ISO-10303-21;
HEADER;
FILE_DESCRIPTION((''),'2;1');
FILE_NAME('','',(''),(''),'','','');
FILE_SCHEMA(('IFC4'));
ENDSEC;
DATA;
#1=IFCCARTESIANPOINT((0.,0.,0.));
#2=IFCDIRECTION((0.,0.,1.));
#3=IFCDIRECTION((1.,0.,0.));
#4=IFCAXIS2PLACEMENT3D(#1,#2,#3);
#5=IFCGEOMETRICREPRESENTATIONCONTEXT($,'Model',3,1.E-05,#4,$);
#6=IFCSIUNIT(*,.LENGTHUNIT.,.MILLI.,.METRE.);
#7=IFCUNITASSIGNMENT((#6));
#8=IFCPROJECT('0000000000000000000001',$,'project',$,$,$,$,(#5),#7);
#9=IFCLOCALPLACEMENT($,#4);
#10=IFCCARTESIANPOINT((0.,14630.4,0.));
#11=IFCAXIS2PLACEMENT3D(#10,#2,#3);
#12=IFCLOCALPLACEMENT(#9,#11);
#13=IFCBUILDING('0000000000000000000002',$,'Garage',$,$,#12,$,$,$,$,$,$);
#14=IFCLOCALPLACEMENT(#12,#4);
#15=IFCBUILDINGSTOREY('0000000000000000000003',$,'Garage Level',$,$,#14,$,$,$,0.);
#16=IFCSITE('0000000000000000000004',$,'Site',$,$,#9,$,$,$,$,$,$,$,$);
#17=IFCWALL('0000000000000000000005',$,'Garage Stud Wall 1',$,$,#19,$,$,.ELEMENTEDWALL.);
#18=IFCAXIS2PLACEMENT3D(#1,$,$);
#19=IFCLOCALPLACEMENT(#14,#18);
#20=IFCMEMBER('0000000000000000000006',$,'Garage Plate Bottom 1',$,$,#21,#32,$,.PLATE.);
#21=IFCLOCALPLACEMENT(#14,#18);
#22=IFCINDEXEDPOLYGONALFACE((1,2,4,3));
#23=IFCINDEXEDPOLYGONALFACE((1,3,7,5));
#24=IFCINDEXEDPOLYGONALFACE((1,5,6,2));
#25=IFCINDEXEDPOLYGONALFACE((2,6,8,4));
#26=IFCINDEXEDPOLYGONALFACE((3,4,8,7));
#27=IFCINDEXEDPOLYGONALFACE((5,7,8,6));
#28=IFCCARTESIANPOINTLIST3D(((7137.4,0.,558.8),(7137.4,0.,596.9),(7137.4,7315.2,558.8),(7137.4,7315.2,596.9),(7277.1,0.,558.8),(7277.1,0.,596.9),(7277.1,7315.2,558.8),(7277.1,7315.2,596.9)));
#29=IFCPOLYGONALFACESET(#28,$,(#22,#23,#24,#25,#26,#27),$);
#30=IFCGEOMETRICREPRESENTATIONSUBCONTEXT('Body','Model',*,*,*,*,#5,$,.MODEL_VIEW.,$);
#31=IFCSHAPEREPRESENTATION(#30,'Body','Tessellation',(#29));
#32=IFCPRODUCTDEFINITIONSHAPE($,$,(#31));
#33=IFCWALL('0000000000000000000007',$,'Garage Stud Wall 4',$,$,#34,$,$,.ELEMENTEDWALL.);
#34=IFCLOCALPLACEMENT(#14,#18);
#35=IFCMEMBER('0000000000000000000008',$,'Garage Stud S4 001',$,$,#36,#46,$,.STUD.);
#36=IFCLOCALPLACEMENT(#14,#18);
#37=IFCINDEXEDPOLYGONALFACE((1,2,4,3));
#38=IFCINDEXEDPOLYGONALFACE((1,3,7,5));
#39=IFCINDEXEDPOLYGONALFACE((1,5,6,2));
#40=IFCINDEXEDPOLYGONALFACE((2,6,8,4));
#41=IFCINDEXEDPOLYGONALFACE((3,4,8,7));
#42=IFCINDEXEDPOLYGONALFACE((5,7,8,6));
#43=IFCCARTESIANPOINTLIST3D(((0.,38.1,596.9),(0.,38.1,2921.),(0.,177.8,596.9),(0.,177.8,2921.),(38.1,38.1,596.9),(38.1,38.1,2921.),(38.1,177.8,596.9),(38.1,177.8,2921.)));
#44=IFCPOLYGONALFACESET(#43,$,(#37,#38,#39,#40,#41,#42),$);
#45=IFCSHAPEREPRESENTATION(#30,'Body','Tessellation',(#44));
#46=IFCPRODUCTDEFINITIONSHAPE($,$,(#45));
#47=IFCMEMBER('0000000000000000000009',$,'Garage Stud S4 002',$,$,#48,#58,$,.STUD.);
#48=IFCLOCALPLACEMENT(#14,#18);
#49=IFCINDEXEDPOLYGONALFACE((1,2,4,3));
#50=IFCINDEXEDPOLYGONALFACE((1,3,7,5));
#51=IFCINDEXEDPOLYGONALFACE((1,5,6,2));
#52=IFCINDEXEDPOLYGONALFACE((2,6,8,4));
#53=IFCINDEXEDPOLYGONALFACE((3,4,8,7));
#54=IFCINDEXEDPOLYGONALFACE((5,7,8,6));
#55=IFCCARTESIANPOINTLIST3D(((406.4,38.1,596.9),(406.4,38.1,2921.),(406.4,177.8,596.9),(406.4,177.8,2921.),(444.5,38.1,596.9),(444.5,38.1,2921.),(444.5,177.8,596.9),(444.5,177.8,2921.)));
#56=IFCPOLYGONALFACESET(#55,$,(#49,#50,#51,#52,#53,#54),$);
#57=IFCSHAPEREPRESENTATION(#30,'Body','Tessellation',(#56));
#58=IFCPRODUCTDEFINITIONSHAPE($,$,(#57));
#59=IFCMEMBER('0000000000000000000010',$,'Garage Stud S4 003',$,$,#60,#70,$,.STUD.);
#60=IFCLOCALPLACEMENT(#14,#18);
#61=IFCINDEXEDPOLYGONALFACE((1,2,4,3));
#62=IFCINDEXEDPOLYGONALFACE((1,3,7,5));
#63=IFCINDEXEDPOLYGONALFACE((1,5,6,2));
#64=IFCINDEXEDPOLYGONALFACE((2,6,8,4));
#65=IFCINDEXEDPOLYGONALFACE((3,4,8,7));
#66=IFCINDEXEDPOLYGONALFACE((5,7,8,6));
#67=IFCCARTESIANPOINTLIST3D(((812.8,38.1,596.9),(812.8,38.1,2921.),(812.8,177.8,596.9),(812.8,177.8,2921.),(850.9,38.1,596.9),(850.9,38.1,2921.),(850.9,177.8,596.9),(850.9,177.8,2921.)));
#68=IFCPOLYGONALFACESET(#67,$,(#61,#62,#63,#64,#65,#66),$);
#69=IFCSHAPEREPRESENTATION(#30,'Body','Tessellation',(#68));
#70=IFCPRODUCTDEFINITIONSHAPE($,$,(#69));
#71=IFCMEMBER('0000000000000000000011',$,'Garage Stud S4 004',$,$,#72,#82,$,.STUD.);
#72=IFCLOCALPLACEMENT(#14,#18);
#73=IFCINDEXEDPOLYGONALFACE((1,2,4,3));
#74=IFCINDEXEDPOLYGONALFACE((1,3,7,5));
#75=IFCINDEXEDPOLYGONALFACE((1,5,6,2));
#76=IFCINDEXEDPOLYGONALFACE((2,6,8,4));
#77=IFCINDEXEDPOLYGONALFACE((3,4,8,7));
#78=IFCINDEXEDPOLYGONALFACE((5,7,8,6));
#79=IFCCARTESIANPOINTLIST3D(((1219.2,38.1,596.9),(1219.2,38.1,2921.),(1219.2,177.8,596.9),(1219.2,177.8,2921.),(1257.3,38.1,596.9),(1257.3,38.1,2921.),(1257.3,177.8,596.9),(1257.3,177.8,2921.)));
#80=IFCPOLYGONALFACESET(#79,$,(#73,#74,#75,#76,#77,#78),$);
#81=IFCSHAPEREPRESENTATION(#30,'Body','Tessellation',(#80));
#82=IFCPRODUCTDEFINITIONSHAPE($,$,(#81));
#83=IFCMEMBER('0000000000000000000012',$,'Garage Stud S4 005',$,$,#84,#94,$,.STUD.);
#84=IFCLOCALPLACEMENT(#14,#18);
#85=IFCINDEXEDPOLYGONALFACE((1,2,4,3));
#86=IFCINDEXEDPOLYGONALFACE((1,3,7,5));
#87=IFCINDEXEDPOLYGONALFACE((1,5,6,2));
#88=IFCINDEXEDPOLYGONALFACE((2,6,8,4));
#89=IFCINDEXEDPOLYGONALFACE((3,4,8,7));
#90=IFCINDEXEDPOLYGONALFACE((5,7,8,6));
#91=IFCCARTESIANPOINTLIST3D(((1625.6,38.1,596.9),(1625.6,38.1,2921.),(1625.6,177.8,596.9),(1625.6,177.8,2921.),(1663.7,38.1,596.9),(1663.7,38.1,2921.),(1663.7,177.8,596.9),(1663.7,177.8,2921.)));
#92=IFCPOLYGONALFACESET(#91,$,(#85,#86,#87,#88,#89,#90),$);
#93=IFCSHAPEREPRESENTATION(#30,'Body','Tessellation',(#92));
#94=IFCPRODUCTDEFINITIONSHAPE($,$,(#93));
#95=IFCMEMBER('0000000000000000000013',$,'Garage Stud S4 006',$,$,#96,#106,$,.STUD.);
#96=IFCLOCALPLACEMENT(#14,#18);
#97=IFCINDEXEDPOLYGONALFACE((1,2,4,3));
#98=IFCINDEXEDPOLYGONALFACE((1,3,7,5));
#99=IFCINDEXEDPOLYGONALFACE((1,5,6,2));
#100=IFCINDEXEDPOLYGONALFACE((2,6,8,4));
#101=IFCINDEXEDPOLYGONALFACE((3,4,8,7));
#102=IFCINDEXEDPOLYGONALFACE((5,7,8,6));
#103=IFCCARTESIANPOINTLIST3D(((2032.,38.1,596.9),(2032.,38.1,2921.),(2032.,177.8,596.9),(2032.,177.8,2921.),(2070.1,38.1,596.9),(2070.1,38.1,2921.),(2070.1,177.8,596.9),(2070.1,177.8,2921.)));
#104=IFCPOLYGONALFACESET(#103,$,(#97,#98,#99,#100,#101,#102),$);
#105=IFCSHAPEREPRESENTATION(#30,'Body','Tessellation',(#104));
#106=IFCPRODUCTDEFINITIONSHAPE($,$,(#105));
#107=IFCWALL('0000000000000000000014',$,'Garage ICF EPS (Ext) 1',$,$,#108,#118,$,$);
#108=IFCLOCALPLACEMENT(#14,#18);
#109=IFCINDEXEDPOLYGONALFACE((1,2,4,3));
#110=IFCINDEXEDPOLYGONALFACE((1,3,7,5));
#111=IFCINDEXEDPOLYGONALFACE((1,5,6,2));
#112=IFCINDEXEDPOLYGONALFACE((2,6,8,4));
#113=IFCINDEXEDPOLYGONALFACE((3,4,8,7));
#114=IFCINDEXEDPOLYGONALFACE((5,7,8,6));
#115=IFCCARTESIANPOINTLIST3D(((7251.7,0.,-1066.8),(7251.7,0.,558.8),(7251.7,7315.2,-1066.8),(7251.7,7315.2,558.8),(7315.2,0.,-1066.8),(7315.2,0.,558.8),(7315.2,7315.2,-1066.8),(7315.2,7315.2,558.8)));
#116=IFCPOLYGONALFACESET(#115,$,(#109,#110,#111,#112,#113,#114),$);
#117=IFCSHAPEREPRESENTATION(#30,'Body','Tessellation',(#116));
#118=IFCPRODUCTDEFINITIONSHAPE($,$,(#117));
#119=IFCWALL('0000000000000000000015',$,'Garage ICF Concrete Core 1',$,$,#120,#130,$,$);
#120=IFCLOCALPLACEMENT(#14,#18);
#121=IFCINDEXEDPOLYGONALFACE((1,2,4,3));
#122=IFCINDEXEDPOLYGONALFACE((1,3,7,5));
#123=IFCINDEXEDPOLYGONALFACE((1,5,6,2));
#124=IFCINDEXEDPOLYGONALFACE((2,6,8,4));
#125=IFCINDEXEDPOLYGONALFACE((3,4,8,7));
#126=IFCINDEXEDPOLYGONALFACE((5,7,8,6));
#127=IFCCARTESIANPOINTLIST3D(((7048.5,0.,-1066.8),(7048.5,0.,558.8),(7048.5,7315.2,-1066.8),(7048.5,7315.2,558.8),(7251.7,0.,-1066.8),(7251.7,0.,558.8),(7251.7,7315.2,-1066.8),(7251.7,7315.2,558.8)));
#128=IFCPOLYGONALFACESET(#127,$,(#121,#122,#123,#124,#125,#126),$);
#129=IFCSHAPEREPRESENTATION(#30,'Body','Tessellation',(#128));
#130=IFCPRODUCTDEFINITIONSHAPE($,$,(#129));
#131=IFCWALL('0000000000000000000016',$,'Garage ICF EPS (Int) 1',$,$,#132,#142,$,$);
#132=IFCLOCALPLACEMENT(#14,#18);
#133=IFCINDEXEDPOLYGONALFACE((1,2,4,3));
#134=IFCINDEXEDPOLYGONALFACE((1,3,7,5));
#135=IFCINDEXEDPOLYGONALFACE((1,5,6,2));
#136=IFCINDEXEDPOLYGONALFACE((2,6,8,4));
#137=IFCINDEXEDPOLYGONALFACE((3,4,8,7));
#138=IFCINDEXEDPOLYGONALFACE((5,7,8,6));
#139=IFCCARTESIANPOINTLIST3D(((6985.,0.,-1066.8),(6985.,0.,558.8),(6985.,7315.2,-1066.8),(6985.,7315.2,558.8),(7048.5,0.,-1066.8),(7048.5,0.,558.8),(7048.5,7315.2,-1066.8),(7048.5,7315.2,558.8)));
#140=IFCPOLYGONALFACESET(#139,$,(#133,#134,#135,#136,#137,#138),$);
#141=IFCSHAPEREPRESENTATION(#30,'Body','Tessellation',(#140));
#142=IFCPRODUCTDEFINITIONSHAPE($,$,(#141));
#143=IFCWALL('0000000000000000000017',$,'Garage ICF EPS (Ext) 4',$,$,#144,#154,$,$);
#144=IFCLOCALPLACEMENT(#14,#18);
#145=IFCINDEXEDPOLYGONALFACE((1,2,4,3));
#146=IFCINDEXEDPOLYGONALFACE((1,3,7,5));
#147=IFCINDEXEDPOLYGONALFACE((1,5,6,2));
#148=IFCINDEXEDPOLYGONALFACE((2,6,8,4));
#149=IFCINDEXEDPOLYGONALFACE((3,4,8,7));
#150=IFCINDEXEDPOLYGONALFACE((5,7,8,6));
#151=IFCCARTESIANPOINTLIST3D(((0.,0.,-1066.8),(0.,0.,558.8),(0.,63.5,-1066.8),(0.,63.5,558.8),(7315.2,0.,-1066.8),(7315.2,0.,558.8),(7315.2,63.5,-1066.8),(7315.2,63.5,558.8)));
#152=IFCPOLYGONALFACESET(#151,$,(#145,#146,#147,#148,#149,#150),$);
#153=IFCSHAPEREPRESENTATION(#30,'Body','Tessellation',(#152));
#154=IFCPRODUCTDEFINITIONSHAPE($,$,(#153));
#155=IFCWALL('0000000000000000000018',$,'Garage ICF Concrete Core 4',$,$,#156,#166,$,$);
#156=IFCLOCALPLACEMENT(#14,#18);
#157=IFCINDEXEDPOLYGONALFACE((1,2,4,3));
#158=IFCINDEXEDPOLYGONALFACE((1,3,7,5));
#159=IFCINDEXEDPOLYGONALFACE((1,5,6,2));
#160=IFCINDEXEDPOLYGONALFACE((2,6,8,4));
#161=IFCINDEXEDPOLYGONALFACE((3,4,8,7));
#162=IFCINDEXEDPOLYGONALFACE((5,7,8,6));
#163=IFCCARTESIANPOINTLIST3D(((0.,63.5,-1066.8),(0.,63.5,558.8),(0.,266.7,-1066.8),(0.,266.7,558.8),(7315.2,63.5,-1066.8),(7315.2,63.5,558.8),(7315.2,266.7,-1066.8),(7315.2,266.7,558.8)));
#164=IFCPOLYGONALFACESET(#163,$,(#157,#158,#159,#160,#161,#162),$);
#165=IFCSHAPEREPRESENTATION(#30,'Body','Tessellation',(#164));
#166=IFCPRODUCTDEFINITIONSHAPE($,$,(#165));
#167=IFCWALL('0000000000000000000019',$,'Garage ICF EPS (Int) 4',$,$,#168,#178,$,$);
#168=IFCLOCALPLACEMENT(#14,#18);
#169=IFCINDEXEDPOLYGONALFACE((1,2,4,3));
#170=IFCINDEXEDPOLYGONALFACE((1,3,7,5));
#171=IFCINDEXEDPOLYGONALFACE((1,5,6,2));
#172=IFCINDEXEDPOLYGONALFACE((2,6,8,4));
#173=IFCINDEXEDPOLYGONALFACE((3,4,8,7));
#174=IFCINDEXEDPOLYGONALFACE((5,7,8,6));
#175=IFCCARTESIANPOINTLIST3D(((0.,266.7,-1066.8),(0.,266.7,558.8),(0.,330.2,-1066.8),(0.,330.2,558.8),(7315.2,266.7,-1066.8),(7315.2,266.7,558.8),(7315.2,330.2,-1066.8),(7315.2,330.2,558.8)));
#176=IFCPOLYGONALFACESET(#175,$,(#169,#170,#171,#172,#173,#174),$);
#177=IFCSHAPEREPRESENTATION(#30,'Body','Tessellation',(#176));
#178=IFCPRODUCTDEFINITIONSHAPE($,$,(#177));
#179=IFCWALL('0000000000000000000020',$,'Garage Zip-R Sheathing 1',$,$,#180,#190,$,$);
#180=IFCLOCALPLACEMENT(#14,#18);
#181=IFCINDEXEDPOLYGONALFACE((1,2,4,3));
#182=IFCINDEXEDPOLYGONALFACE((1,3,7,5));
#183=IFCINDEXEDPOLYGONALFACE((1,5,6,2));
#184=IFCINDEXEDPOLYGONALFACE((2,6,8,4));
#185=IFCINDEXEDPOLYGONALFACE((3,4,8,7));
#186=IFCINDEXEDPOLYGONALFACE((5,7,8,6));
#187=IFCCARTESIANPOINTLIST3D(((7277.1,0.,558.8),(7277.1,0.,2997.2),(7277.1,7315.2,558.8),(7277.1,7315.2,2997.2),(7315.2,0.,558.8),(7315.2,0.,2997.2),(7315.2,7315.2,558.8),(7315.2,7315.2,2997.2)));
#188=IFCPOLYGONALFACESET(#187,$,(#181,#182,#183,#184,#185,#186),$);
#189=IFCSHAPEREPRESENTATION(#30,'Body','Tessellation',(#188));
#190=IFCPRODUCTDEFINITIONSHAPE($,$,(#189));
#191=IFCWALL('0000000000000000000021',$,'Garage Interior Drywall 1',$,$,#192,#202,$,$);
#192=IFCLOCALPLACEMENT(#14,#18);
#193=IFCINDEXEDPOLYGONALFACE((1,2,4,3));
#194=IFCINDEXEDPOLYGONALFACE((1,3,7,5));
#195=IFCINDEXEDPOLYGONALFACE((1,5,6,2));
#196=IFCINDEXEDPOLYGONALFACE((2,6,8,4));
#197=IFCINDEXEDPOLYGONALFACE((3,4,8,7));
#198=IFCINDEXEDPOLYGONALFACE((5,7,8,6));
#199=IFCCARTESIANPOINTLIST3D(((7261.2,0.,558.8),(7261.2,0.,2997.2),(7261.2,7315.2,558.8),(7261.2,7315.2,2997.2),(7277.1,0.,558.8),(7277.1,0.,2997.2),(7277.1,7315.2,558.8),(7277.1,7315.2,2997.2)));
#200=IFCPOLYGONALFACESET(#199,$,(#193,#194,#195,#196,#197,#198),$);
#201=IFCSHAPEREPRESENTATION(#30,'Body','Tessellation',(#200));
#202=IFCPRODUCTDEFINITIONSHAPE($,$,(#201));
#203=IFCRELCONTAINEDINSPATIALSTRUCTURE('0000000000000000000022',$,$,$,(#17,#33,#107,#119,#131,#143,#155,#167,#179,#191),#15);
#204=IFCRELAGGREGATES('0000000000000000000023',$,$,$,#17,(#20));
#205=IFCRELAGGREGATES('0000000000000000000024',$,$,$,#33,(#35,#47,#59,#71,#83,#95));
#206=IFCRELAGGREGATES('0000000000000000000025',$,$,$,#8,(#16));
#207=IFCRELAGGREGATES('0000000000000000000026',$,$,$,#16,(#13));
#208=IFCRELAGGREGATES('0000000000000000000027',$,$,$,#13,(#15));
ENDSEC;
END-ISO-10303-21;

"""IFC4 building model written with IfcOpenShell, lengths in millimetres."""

from ifc_helpers import new_model, si_unit, frame, origin_with_axes, origin_2d, place, context, subcontext, project, spatial, indexed_curve, rectangle, outline, extrude, element, aggregate, save


model = new_model("IFC4")

# Units and contexts
model_context = context("Model", 3, precision=1e-05, world=origin_with_axes())
body_context = subcontext(model_context, "Body", "Model", "MODEL_VIEW")
ifc_project = project(units=[si_unit("LENGTHUNIT", "METRE", prefix="MILLI")], contexts=[model_context])

# Site, building, storey
site_placement = place(None, origin_with_axes())
site = spatial("IfcSite", under=ifc_project, at=site_placement, Name="Site")
building_placement = place(site_placement, frame((0.0, 14630.4, 0.0), z_axis=(0.0, 0.0, 1.0), x_axis=(1.0, 0.0, 0.0)))
building = spatial("IfcBuilding", under=site, at=building_placement, Name="Garage")
storey_placement = place(building_placement, origin_with_axes())
storey = spatial("IfcBuildingStorey", under=building, at=storey_placement, Name="Garage Level", Elevation=0.0)

# Wall, member
wall_1_placement = place(storey_placement, frame((7315.2, 0.0, 558.8), z_axis=(0.0, 0.0, 1.0), x_axis=(0.0, 1.0, 0.0)))
wall_1 = element("IfcWall", 1, at=wall_1_placement, inside=storey, Name="Garage Stud Wall 1", PredefinedType="ELEMENTEDWALL")
member_1_placement = place(wall_1_placement, frame((0.0, 108.0, 19.1), z_axis=(1.0, 0.0, 0.0), x_axis=(0.0, 0.0, 1.0)))
member_1 = element("IfcMember", 2, at=member_1_placement, Name="Garage Plate Bottom 1", PredefinedType="PLATE", context=body_context, shape_type="SweptSolid", body=[
    extrude(rectangle(XDim=38.1, YDim=139.7, at=origin_2d()), origin_with_axes(), (0.0, 0.0, 1.0), 7315.2),
])
aggregate(wall_1, [member_1])

# Wall, members
wall_2_placement = place(storey_placement, frame((0.0, 0.0, 558.8), z_axis=(0.0, 0.0, 1.0), x_axis=(1.0, 0.0, 0.0)))
wall_2 = element("IfcWall", 3, at=wall_2_placement, inside=storey, Name="Garage Stud Wall 4", PredefinedType="ELEMENTEDWALL")
member_2_placement = place(wall_2_placement, frame((19.1, 108.0, 38.1), z_axis=(0.0, 0.0, 1.0), x_axis=(1.0, 0.0, 0.0)))
member_2 = element("IfcMember", 4, at=member_2_placement, Name="Garage Stud S4 001", PredefinedType="STUD", context=body_context, shape_type="SweptSolid", body=[
    extrude(rectangle(XDim=38.1, YDim=139.7, at=origin_2d()), origin_with_axes(), (0.0, 0.0, 1.0), 2324.1),
])
member_3_placement = place(wall_2_placement, frame((425.4, 108.0, 38.1), z_axis=(0.0, 0.0, 1.0), x_axis=(1.0, 0.0, 0.0)))
member_3 = element("IfcMember", 5, at=member_3_placement, Name="Garage Stud S4 002", PredefinedType="STUD", context=body_context, shape_type="SweptSolid", body=[
    extrude(rectangle(XDim=38.1, YDim=139.7, at=origin_2d()), origin_with_axes(), (0.0, 0.0, 1.0), 2324.1),
])
member_4_placement = place(wall_2_placement, frame((831.9, 108.0, 38.1), z_axis=(0.0, 0.0, 1.0), x_axis=(1.0, 0.0, 0.0)))
member_4 = element("IfcMember", 6, at=member_4_placement, Name="Garage Stud S4 003", PredefinedType="STUD", context=body_context, shape_type="SweptSolid", body=[
    extrude(rectangle(XDim=38.1, YDim=139.7, at=origin_2d()), origin_with_axes(), (0.0, 0.0, 1.0), 2324.1),
])
member_5_placement = place(wall_2_placement, frame((1238.2, 108.0, 38.1), z_axis=(0.0, 0.0, 1.0), x_axis=(1.0, 0.0, 0.0)))
member_5 = element("IfcMember", 7, at=member_5_placement, Name="Garage Stud S4 004", PredefinedType="STUD", context=body_context, shape_type="SweptSolid", body=[
    extrude(rectangle(XDim=38.1, YDim=139.7, at=origin_2d()), origin_with_axes(), (0.0, 0.0, 1.0), 2324.1),
])
member_6_placement = place(wall_2_placement, frame((1644.7, 108.0, 38.1), z_axis=(0.0, 0.0, 1.0), x_axis=(1.0, 0.0, 0.0)))
member_6 = element("IfcMember", 8, at=member_6_placement, Name="Garage Stud S4 005", PredefinedType="STUD", context=body_context, shape_type="SweptSolid", body=[
    extrude(rectangle(XDim=38.1, YDim=139.7, at=origin_2d()), origin_with_axes(), (0.0, 0.0, 1.0), 2324.1),
])
member_7_placement = place(wall_2_placement, frame((2051.1, 108.0, 38.1), z_axis=(0.0, 0.0, 1.0), x_axis=(1.0, 0.0, 0.0)))
member_7 = element("IfcMember", 9, at=member_7_placement, Name="Garage Stud S4 006", PredefinedType="STUD", context=body_context, shape_type="SweptSolid", body=[
    extrude(rectangle(XDim=38.1, YDim=139.7, at=origin_2d()), origin_with_axes(), (0.0, 0.0, 1.0), 2324.1),
])
aggregate(wall_2, [member_2, member_3, member_4, member_5, member_6, member_7])

# Walls
wall_3_placement = place(storey_placement, frame((7315.2, 0.0, -1066.8), z_axis=(0.0, 0.0, 1.0), x_axis=(0.0, 1.0, 0.0)))
element("IfcWall", 10, at=wall_3_placement, inside=storey, Name="Garage ICF EPS (Ext) 1", context=body_context, shape_type="SweptSolid", body=[
    extrude(outline(indexed_curve([(0.0, 0.0), (0.0, 63.5), (7315.2, 63.5), (7315.2, 0.0), (0.0, 0.0)], self_intersect=False)), origin_with_axes(), (0.0, 0.0, 1.0), 1625.6),
])
wall_4_placement = place(storey_placement, frame((7315.2, 0.0, -1066.8), z_axis=(0.0, 0.0, 1.0), x_axis=(0.0, 1.0, 0.0)))
element("IfcWall", 11, at=wall_4_placement, inside=storey, Name="Garage ICF Concrete Core 1", context=body_context, shape_type="SweptSolid", body=[
    extrude(outline(indexed_curve([(0.0, 0.0), (0.0, 203.2), (7315.2, 203.2), (7315.2, 0.0), (0.0, 0.0)], self_intersect=False)), frame((0.0, 63.5, 0.0), z_axis=(0.0, 0.0, 1.0), x_axis=(1.0, 0.0, 0.0)), (0.0, 0.0, 1.0), 1625.6),
])
wall_5_placement = place(storey_placement, frame((7315.2, 0.0, -1066.8), z_axis=(0.0, 0.0, 1.0), x_axis=(0.0, 1.0, 0.0)))
element("IfcWall", 12, at=wall_5_placement, inside=storey, Name="Garage ICF EPS (Int) 1", context=body_context, shape_type="SweptSolid", body=[
    extrude(outline(indexed_curve([(0.0, 0.0), (0.0, 63.5), (7315.2, 63.5), (7315.2, 0.0), (0.0, 0.0)], self_intersect=False)), frame((0.0, 266.7, 0.0), z_axis=(0.0, 0.0, 1.0), x_axis=(1.0, 0.0, 0.0)), (0.0, 0.0, 1.0), 1625.6),
])
wall_6_placement = place(storey_placement, frame((0.0, 0.0, -1066.8), z_axis=(0.0, 0.0, 1.0), x_axis=(1.0, 0.0, 0.0)))
element("IfcWall", 13, at=wall_6_placement, inside=storey, Name="Garage ICF EPS (Ext) 4", context=body_context, shape_type="SweptSolid", body=[
    extrude(outline(indexed_curve([(0.0, 0.0), (0.0, 63.5), (7315.2, 63.5), (7315.2, 0.0), (0.0, 0.0)], self_intersect=False)), origin_with_axes(), (0.0, 0.0, 1.0), 1625.6),
])
wall_7_placement = place(storey_placement, frame((0.0, 0.0, -1066.8), z_axis=(0.0, 0.0, 1.0), x_axis=(1.0, 0.0, 0.0)))
element("IfcWall", 14, at=wall_7_placement, inside=storey, Name="Garage ICF Concrete Core 4", context=body_context, shape_type="SweptSolid", body=[
    extrude(outline(indexed_curve([(0.0, 0.0), (0.0, 203.2), (7315.2, 203.2), (7315.2, 0.0), (0.0, 0.0)], self_intersect=False)), frame((0.0, 63.5, 0.0), z_axis=(0.0, 0.0, 1.0), x_axis=(1.0, 0.0, 0.0)), (0.0, 0.0, 1.0), 1625.6),
])
wall_8_placement = place(storey_placement, frame((0.0, 0.0, -1066.8), z_axis=(0.0, 0.0, 1.0), x_axis=(1.0, 0.0, 0.0)))
element("IfcWall", 15, at=wall_8_placement, inside=storey, Name="Garage ICF EPS (Int) 4", context=body_context, shape_type="SweptSolid", body=[
    extrude(outline(indexed_curve([(0.0, 0.0), (0.0, 63.5), (7315.2, 63.5), (7315.2, 0.0), (0.0, 0.0)], self_intersect=False)), frame((0.0, 266.7, 0.0), z_axis=(0.0, 0.0, 1.0), x_axis=(1.0, 0.0, 0.0)), (0.0, 0.0, 1.0), 1625.6),
])
wall_9_placement = place(storey_placement, frame((7315.2, 0.0, 558.8), z_axis=(0.0, 0.0, 1.0), x_axis=(0.0, 1.0, 0.0)))
element("IfcWall", 16, at=wall_9_placement, inside=storey, Name="Garage Zip-R Sheathing 1", context=body_context, shape_type="SweptSolid", body=[
    extrude(outline(indexed_curve([(0.0, 0.0), (0.0, 38.1), (7315.2, 38.1), (7315.2, 0.0), (0.0, 0.0)], self_intersect=False)), origin_with_axes(), (0.0, 0.0, 1.0), 2438.4),
])
wall_10_placement = place(storey_placement, frame((7315.2, 0.0, 558.8), z_axis=(0.0, 0.0, 1.0), x_axis=(0.0, 1.0, 0.0)))
element("IfcWall", 17, at=wall_10_placement, inside=storey, Name="Garage Interior Drywall 1", context=body_context, shape_type="SweptSolid", body=[
    extrude(outline(indexed_curve([(0.0, 0.0), (0.0, 15.9), (7315.2, 15.9), (7315.2, 0.0), (0.0, 0.0)], self_intersect=False)), frame((0.0, 38.1, 0.0), z_axis=(0.0, 0.0, 1.0), x_axis=(1.0, 0.0, 0.0)), (0.0, 0.0, 1.0), 2438.4),
])

save(model, "model.ifc")
